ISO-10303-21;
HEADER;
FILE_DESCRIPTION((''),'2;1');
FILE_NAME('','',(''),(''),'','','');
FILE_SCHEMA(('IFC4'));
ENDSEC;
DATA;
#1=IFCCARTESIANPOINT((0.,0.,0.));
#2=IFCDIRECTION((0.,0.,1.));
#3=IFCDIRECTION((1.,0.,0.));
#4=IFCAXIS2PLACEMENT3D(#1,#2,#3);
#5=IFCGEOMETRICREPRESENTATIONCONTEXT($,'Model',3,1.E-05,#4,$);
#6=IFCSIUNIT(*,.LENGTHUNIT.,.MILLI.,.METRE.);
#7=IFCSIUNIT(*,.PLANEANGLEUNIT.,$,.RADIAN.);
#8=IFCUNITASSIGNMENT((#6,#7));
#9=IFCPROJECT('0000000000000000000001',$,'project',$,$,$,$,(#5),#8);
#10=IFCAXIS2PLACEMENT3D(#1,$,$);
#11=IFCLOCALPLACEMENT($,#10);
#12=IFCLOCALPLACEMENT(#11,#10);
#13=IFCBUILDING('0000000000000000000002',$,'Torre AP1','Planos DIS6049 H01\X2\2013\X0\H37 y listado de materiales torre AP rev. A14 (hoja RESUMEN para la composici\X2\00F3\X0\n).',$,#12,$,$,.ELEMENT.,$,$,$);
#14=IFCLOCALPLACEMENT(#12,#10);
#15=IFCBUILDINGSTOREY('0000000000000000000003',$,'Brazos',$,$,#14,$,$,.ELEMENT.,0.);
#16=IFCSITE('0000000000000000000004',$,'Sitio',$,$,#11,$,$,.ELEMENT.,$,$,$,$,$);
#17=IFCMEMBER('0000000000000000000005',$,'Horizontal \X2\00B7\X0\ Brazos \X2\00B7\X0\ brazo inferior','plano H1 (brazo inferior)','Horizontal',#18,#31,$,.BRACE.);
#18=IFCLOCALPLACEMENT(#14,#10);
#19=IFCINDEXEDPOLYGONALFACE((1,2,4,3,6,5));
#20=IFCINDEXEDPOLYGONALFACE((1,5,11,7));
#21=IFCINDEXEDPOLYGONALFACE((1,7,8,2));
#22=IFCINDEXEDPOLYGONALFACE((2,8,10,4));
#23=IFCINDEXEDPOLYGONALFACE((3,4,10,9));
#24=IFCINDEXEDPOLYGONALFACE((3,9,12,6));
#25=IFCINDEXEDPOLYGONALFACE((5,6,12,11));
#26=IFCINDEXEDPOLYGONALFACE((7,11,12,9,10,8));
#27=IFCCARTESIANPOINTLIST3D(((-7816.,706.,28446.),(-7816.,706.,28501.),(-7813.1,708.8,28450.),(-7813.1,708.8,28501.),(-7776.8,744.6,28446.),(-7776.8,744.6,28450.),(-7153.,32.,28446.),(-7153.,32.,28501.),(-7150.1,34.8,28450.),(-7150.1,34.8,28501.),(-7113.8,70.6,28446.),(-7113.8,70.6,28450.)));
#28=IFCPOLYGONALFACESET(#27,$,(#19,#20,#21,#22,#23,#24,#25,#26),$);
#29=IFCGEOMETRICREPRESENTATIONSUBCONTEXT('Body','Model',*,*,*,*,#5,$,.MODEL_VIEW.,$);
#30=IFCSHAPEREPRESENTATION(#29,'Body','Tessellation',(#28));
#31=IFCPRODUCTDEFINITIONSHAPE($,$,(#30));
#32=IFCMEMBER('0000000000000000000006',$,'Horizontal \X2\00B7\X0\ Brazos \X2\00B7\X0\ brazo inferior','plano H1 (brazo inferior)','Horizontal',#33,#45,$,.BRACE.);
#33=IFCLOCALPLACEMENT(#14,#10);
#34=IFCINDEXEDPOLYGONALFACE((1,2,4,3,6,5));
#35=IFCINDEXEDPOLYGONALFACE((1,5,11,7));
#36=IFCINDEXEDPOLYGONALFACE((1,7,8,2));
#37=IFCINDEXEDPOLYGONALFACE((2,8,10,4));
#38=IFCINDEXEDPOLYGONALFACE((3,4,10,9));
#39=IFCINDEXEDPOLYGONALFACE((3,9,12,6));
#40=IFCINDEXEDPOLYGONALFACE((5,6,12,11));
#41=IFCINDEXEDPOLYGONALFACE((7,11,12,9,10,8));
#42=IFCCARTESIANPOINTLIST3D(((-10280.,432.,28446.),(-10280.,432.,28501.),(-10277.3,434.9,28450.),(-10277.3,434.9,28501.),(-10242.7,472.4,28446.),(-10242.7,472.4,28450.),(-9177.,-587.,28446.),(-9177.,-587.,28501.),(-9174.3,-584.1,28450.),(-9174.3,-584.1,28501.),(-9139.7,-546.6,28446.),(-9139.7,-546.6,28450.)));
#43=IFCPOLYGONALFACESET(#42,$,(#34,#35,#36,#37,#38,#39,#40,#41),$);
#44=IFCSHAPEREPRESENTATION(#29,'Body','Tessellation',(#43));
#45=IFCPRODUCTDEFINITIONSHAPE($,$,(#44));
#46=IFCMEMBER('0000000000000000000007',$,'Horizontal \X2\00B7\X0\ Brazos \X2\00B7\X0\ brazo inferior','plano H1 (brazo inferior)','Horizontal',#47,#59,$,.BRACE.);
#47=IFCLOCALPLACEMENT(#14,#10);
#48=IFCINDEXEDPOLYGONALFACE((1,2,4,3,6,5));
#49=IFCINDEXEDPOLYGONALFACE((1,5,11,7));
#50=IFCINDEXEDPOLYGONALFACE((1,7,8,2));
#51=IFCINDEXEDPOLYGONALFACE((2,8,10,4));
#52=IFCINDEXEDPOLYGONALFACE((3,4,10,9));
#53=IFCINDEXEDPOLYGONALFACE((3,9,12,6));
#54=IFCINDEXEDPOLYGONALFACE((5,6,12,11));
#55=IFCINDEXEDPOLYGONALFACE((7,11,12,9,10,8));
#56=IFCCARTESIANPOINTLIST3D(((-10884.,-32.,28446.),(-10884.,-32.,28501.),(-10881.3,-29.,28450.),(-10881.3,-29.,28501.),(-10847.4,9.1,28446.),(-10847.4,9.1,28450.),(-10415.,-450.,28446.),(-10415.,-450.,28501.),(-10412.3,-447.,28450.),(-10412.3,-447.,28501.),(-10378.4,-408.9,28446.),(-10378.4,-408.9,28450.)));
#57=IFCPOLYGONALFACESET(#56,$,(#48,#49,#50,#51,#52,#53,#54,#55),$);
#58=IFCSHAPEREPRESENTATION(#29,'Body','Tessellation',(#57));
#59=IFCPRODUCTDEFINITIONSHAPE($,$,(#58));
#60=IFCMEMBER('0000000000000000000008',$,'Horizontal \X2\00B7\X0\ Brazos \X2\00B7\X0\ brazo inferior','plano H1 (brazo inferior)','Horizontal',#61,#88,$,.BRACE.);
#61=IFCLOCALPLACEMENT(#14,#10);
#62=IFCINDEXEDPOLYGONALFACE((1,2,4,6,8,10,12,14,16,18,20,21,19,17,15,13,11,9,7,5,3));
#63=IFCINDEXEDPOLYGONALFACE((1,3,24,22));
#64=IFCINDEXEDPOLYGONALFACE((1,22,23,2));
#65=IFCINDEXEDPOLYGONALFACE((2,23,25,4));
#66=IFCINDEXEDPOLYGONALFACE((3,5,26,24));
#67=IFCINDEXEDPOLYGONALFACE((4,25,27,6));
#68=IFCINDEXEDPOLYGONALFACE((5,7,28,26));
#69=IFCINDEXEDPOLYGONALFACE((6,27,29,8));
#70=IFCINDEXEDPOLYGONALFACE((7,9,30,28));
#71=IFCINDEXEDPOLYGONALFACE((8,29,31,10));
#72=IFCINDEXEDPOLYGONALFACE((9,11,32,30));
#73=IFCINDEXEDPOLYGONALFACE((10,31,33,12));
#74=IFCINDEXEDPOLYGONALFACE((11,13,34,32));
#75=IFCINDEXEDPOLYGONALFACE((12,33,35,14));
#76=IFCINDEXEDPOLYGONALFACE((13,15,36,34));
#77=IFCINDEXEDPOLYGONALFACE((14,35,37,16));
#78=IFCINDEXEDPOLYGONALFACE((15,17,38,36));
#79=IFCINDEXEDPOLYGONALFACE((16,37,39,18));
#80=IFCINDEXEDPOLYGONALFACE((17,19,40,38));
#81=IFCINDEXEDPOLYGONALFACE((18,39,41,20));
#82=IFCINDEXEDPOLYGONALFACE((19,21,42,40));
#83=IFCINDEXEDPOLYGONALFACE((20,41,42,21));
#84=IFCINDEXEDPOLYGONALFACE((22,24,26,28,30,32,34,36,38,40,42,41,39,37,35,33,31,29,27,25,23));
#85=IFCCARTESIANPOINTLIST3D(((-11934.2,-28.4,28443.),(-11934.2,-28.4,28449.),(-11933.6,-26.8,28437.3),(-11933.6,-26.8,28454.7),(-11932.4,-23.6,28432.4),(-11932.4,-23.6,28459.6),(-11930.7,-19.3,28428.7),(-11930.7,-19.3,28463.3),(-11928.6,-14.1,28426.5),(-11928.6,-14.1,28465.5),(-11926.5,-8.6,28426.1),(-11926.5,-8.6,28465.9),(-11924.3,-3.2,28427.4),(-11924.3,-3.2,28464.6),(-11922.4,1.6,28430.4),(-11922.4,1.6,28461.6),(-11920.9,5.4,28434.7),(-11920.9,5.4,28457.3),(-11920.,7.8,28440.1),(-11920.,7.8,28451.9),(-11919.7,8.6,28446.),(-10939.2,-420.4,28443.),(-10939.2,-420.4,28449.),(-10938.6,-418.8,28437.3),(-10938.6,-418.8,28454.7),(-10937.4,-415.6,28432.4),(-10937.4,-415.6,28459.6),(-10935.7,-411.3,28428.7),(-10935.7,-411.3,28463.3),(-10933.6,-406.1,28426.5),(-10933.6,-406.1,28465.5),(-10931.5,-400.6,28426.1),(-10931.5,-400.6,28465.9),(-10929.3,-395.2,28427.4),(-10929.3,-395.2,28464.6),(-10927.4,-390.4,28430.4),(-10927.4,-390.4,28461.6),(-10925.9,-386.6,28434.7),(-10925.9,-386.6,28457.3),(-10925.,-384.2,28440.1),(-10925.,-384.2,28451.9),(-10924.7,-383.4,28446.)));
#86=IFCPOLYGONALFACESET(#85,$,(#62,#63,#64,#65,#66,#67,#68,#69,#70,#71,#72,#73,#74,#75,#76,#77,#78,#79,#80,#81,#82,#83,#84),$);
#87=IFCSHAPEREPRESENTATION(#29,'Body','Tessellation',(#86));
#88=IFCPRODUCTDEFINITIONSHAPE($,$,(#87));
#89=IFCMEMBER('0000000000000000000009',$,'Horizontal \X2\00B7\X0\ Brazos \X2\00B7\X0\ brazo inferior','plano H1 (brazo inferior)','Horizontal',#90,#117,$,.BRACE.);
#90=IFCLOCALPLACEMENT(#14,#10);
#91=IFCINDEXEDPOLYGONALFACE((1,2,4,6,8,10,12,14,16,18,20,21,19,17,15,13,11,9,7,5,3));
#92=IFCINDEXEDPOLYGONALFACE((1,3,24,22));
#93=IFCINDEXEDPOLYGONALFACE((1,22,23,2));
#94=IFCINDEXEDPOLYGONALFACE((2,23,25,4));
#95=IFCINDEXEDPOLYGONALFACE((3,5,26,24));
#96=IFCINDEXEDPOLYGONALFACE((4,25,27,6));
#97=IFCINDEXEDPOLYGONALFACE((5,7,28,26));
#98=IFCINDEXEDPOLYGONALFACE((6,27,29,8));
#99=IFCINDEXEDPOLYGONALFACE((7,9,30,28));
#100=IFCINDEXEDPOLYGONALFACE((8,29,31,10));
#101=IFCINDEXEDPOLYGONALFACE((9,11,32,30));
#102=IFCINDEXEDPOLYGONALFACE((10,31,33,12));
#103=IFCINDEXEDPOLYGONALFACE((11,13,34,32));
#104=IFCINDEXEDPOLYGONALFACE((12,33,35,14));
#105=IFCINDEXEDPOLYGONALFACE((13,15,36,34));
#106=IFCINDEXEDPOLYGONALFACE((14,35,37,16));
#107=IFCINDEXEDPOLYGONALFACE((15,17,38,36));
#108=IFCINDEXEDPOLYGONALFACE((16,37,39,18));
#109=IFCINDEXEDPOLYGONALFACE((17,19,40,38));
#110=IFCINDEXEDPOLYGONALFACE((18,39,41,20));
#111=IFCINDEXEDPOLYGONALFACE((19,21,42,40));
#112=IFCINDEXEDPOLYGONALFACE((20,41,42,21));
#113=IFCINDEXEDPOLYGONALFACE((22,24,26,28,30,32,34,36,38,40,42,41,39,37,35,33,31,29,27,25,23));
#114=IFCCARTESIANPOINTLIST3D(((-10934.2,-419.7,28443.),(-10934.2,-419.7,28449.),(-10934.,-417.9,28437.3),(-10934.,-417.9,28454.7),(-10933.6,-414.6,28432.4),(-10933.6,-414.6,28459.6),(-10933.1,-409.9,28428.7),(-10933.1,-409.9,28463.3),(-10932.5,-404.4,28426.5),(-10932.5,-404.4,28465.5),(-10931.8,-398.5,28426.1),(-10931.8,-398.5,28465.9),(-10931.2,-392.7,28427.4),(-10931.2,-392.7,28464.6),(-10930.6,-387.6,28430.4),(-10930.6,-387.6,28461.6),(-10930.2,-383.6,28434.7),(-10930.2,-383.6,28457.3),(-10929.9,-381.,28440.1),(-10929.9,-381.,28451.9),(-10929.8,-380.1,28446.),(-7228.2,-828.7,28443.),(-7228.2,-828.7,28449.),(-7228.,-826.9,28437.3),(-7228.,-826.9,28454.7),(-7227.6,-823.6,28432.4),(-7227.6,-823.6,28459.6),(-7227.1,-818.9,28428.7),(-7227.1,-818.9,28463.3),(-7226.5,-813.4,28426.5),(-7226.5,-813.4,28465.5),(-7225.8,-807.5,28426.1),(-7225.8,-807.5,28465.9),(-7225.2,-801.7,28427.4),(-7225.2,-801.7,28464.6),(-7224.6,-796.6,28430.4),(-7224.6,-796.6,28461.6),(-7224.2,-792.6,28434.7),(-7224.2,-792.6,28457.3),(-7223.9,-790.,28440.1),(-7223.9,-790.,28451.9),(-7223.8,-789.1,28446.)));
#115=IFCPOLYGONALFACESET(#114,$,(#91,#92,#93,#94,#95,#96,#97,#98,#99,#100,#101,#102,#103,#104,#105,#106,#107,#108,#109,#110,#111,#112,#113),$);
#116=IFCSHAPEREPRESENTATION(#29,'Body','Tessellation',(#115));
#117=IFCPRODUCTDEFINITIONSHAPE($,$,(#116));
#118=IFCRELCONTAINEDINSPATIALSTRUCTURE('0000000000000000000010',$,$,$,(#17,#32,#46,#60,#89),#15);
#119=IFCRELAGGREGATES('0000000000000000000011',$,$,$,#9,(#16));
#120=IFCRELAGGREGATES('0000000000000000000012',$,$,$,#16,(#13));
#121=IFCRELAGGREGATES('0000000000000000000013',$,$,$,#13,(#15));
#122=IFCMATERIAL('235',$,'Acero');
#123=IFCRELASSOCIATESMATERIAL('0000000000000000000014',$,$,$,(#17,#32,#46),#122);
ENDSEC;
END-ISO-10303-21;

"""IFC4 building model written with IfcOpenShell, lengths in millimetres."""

from ifc_helpers import new_model, si_unit, frame, frame_2d, origin, origin_with_axes, place, context, subcontext, project, spatial, circle, l_section, extrude, material, element, save


model = new_model("IFC4")

# Units and contexts
model_context = context("Model", 3, precision=1e-05, world=origin_with_axes())
body_context = subcontext(model_context, "Body", "Model", "MODEL_VIEW")
ifc_project = project(units=[si_unit("LENGTHUNIT", "METRE", prefix="MILLI"), si_unit("PLANEANGLEUNIT", "RADIAN")], contexts=[model_context])

# Site, building, storey
site_placement = place(None, origin())
site = spatial("IfcSite", under=ifc_project, at=site_placement, Name="Sitio", CompositionType="ELEMENT")
building_placement = place(site_placement, origin())
building = spatial("IfcBuilding", under=site, at=building_placement, Name="Torre AP1", Description="Planos DIS6049 H01–H37 y listado de materiales torre AP rev. A14 (hoja RESUMEN para la composición).", CompositionType="ELEMENT")
storey_placement = place(building_placement, origin())
storey = spatial("IfcBuildingStorey", under=building, at=storey_placement, Name="Brazos", CompositionType="ELEMENT", Elevation=0.0)

# Members
ifc_material_1 = material(Name="235", Category="Acero")
member_1_placement = place(storey_placement, frame((-7816.0, 706.0, 28446.0), z_axis=(0.701265, -0.7129, 0.0), x_axis=(0.7129, 0.701265, 0.0)))
element("IfcMember", 1, at=member_1_placement, inside=storey, material=ifc_material_1, Name="Horizontal · Brazos · brazo inferior", Description="plano H1 (brazo inferior)", ObjectType="Horizontal", PredefinedType="BRACE", context=body_context, shape_type="SweptSolid", body=[
    extrude(l_section(Depth=55.0, Width=55.0, Thickness=4.0, at=frame_2d((27.5, 27.5))), None, (0.0, 0.0, 1.0), 945.4),
])
member_2_placement = place(storey_placement, frame((-10280.0, 432.0, 28446.0), z_axis=(0.734523, -0.678584, 0.0), x_axis=(0.678584, 0.734523, 0.0)))
element("IfcMember", 2, at=member_2_placement, inside=storey, material=ifc_material_1, Name="Horizontal · Brazos · brazo inferior", Description="plano H1 (brazo inferior)", ObjectType="Horizontal", PredefinedType="BRACE", context=body_context, shape_type="SweptSolid", body=[
    extrude(l_section(Depth=55.0, Width=55.0, Thickness=4.0, at=frame_2d((27.5, 27.5))), None, (0.0, 0.0, 1.0), 1501.7),
])
member_3_placement = place(storey_placement, frame((-10884.0, -32.0, 28446.0), z_axis=(0.74653, -0.665351, 0.0), x_axis=(0.665351, 0.74653, 0.0)))
element("IfcMember", 3, at=member_3_placement, inside=storey, material=ifc_material_1, Name="Horizontal · Brazos · brazo inferior", Description="plano H1 (brazo inferior)", ObjectType="Horizontal", PredefinedType="BRACE", context=body_context, shape_type="SweptSolid", body=[
    extrude(l_section(Depth=55.0, Width=55.0, Thickness=4.0, at=frame_2d((27.5, 27.5))), None, (0.0, 0.0, 1.0), 628.2),
])
member_4_placement = place(storey_placement, frame((-11927.0, -10.0, 28446.0), z_axis=(0.930399, -0.366549, 0.0), x_axis=(0.366549, 0.930399, 0.0)))
element("IfcMember", 4, at=member_4_placement, inside=storey, Name="Horizontal · Brazos · brazo inferior", Description="plano H1 (brazo inferior)", ObjectType="Horizontal", PredefinedType="BRACE", context=body_context, shape_type="SweptSolid", body=[
    extrude(circle(Radius=20.0), None, (0.0, 0.0, 1.0), 1069.4),
])
member_5_placement = place(storey_placement, frame((-10932.0, -400.0, 28446.0), z_axis=(0.993965, -0.109696, 0.0), x_axis=(0.109696, 0.993965, 0.0)))
element("IfcMember", 5, at=member_5_placement, inside=storey, Name="Horizontal · Brazos · brazo inferior", Description="plano H1 (brazo inferior)", ObjectType="Horizontal", PredefinedType="BRACE", context=body_context, shape_type="SweptSolid", body=[
    extrude(circle(Radius=20.0), None, (0.0, 0.0, 1.0), 3728.5),
])

save(model, "model.ifc")
